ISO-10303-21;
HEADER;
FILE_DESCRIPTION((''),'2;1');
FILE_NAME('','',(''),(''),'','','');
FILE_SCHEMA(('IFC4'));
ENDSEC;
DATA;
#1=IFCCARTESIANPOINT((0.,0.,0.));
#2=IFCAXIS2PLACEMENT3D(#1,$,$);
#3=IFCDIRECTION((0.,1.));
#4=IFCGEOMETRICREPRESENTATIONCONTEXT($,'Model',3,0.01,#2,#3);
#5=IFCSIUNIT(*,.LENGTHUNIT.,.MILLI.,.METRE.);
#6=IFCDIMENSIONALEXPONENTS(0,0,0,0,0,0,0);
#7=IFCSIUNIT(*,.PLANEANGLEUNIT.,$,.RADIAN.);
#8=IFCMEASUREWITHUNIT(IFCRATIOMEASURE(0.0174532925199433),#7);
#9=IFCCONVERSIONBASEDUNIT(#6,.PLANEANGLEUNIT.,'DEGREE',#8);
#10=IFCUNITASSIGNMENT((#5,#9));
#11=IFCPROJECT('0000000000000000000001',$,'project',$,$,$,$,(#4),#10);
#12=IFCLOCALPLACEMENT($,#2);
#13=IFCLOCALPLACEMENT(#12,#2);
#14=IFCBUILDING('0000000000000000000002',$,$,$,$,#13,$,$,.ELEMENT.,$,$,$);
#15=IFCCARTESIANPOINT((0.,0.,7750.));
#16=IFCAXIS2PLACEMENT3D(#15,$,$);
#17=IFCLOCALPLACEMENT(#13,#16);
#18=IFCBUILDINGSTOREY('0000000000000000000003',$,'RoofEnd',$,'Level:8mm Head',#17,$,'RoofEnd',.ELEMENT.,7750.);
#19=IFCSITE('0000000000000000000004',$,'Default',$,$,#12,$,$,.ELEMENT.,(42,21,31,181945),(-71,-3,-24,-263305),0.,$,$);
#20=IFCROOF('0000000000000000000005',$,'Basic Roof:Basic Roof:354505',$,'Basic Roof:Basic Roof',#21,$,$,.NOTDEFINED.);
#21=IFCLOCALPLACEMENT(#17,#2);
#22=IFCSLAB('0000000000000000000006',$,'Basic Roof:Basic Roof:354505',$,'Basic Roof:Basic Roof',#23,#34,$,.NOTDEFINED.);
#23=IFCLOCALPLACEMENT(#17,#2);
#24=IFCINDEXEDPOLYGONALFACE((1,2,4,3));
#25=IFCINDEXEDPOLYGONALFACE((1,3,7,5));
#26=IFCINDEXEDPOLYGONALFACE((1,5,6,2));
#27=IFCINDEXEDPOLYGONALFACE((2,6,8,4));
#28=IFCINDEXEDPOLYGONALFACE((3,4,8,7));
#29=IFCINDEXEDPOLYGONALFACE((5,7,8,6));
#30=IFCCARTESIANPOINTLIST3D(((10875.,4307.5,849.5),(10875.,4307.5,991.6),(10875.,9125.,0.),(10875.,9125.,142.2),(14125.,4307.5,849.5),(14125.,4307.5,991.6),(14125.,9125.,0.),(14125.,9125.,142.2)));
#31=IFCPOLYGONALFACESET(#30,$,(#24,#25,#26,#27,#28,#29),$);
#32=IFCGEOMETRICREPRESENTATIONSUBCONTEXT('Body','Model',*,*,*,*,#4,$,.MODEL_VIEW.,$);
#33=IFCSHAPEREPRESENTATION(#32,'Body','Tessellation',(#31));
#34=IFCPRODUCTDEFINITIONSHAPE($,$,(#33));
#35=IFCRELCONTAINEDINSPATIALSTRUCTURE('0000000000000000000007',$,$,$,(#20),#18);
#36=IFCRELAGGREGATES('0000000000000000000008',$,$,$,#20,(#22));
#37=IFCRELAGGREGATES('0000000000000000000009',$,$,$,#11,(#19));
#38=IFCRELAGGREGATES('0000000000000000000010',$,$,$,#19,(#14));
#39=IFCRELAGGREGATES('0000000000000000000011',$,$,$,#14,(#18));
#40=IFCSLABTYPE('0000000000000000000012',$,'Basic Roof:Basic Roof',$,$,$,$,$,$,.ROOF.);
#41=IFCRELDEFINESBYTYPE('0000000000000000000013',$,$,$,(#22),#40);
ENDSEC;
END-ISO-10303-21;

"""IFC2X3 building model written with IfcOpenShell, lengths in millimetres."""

from ifc_helpers import new_model, entity, si_unit, converted_unit, direction, frame, frame_2d, origin, place, context, subcontext, project, spatial, rectangle, extrude, type_object, element, aggregate, save


model = new_model("IFC2X3")

# Units and contexts
model_context = context("Model", 3, precision=0.01, world=origin(), true_north=direction((0.0, 1.0)))
body_context = subcontext(model_context, "Body", "Model", "MODEL_VIEW")
ifc_project = project(units=[si_unit("LENGTHUNIT", "METRE", prefix="MILLI"), converted_unit("PLANEANGLEUNIT", "DEGREE", entity("IfcRatioMeasure", 0.0174532925199433), si_unit("PLANEANGLEUNIT", "RADIAN"), dimensions=[0, 0, 0, 0, 0, 0, 0])], contexts=[model_context])

# Site, building, storey
site_placement = place(None, origin())
site = spatial("IfcSite", under=ifc_project, at=site_placement, Name="Default", CompositionType="ELEMENT", RefLatitude=(42, 21, 31, 181945), RefLongitude=(-71, -3, -24, -263305), RefElevation=0.0)
building_placement = place(site_placement, origin())
building = spatial("IfcBuilding", under=site, at=building_placement, CompositionType="ELEMENT")
storey_placement = place(building_placement, frame((0.0, 0.0, 7750.0)))
storey = spatial("IfcBuildingStorey", under=building, at=storey_placement, Name="RoofEnd", ObjectType="Level:8mm Head", LongName="RoofEnd", CompositionType="ELEMENT", Elevation=7750.0)

# Roof, slab
roof_placement = place(storey_placement, frame((10875.0, 4307.5, 0.0)))
roof = element("IfcRoof", 1, at=roof_placement, inside=storey, Name="Basic Roof:Basic Roof:354505", ObjectType="Basic Roof:Basic Roof", ShapeType="NOTDEFINED")
slab_type = type_object("IfcSlabType", Name="Basic Roof:Basic Roof", PredefinedType="ROOF")
slab_placement = place(roof_placement, origin())
slab = element("IfcSlab", 2, at=slab_placement, type_object=slab_type, Name="Basic Roof:Basic Roof:354505", ObjectType="Basic Roof:Basic Roof", PredefinedType="NOTDEFINED", context=body_context, shape_type="SweptSolid", body=[
    extrude(rectangle(XDim=3250.0, YDim=4891.8, at=frame_2d((0.0, 0.0), x_axis=(1.0, 0.0))), frame((1625.0, 2408.7, 424.7), z_axis=(0.0, 0.173648, 0.984808), x_axis=(1.0, 0.0, 0.0)), (0.0, -0.173648, 0.984808), 142.2),
])
aggregate(roof, [slab])

save(model, "model.ifc")
